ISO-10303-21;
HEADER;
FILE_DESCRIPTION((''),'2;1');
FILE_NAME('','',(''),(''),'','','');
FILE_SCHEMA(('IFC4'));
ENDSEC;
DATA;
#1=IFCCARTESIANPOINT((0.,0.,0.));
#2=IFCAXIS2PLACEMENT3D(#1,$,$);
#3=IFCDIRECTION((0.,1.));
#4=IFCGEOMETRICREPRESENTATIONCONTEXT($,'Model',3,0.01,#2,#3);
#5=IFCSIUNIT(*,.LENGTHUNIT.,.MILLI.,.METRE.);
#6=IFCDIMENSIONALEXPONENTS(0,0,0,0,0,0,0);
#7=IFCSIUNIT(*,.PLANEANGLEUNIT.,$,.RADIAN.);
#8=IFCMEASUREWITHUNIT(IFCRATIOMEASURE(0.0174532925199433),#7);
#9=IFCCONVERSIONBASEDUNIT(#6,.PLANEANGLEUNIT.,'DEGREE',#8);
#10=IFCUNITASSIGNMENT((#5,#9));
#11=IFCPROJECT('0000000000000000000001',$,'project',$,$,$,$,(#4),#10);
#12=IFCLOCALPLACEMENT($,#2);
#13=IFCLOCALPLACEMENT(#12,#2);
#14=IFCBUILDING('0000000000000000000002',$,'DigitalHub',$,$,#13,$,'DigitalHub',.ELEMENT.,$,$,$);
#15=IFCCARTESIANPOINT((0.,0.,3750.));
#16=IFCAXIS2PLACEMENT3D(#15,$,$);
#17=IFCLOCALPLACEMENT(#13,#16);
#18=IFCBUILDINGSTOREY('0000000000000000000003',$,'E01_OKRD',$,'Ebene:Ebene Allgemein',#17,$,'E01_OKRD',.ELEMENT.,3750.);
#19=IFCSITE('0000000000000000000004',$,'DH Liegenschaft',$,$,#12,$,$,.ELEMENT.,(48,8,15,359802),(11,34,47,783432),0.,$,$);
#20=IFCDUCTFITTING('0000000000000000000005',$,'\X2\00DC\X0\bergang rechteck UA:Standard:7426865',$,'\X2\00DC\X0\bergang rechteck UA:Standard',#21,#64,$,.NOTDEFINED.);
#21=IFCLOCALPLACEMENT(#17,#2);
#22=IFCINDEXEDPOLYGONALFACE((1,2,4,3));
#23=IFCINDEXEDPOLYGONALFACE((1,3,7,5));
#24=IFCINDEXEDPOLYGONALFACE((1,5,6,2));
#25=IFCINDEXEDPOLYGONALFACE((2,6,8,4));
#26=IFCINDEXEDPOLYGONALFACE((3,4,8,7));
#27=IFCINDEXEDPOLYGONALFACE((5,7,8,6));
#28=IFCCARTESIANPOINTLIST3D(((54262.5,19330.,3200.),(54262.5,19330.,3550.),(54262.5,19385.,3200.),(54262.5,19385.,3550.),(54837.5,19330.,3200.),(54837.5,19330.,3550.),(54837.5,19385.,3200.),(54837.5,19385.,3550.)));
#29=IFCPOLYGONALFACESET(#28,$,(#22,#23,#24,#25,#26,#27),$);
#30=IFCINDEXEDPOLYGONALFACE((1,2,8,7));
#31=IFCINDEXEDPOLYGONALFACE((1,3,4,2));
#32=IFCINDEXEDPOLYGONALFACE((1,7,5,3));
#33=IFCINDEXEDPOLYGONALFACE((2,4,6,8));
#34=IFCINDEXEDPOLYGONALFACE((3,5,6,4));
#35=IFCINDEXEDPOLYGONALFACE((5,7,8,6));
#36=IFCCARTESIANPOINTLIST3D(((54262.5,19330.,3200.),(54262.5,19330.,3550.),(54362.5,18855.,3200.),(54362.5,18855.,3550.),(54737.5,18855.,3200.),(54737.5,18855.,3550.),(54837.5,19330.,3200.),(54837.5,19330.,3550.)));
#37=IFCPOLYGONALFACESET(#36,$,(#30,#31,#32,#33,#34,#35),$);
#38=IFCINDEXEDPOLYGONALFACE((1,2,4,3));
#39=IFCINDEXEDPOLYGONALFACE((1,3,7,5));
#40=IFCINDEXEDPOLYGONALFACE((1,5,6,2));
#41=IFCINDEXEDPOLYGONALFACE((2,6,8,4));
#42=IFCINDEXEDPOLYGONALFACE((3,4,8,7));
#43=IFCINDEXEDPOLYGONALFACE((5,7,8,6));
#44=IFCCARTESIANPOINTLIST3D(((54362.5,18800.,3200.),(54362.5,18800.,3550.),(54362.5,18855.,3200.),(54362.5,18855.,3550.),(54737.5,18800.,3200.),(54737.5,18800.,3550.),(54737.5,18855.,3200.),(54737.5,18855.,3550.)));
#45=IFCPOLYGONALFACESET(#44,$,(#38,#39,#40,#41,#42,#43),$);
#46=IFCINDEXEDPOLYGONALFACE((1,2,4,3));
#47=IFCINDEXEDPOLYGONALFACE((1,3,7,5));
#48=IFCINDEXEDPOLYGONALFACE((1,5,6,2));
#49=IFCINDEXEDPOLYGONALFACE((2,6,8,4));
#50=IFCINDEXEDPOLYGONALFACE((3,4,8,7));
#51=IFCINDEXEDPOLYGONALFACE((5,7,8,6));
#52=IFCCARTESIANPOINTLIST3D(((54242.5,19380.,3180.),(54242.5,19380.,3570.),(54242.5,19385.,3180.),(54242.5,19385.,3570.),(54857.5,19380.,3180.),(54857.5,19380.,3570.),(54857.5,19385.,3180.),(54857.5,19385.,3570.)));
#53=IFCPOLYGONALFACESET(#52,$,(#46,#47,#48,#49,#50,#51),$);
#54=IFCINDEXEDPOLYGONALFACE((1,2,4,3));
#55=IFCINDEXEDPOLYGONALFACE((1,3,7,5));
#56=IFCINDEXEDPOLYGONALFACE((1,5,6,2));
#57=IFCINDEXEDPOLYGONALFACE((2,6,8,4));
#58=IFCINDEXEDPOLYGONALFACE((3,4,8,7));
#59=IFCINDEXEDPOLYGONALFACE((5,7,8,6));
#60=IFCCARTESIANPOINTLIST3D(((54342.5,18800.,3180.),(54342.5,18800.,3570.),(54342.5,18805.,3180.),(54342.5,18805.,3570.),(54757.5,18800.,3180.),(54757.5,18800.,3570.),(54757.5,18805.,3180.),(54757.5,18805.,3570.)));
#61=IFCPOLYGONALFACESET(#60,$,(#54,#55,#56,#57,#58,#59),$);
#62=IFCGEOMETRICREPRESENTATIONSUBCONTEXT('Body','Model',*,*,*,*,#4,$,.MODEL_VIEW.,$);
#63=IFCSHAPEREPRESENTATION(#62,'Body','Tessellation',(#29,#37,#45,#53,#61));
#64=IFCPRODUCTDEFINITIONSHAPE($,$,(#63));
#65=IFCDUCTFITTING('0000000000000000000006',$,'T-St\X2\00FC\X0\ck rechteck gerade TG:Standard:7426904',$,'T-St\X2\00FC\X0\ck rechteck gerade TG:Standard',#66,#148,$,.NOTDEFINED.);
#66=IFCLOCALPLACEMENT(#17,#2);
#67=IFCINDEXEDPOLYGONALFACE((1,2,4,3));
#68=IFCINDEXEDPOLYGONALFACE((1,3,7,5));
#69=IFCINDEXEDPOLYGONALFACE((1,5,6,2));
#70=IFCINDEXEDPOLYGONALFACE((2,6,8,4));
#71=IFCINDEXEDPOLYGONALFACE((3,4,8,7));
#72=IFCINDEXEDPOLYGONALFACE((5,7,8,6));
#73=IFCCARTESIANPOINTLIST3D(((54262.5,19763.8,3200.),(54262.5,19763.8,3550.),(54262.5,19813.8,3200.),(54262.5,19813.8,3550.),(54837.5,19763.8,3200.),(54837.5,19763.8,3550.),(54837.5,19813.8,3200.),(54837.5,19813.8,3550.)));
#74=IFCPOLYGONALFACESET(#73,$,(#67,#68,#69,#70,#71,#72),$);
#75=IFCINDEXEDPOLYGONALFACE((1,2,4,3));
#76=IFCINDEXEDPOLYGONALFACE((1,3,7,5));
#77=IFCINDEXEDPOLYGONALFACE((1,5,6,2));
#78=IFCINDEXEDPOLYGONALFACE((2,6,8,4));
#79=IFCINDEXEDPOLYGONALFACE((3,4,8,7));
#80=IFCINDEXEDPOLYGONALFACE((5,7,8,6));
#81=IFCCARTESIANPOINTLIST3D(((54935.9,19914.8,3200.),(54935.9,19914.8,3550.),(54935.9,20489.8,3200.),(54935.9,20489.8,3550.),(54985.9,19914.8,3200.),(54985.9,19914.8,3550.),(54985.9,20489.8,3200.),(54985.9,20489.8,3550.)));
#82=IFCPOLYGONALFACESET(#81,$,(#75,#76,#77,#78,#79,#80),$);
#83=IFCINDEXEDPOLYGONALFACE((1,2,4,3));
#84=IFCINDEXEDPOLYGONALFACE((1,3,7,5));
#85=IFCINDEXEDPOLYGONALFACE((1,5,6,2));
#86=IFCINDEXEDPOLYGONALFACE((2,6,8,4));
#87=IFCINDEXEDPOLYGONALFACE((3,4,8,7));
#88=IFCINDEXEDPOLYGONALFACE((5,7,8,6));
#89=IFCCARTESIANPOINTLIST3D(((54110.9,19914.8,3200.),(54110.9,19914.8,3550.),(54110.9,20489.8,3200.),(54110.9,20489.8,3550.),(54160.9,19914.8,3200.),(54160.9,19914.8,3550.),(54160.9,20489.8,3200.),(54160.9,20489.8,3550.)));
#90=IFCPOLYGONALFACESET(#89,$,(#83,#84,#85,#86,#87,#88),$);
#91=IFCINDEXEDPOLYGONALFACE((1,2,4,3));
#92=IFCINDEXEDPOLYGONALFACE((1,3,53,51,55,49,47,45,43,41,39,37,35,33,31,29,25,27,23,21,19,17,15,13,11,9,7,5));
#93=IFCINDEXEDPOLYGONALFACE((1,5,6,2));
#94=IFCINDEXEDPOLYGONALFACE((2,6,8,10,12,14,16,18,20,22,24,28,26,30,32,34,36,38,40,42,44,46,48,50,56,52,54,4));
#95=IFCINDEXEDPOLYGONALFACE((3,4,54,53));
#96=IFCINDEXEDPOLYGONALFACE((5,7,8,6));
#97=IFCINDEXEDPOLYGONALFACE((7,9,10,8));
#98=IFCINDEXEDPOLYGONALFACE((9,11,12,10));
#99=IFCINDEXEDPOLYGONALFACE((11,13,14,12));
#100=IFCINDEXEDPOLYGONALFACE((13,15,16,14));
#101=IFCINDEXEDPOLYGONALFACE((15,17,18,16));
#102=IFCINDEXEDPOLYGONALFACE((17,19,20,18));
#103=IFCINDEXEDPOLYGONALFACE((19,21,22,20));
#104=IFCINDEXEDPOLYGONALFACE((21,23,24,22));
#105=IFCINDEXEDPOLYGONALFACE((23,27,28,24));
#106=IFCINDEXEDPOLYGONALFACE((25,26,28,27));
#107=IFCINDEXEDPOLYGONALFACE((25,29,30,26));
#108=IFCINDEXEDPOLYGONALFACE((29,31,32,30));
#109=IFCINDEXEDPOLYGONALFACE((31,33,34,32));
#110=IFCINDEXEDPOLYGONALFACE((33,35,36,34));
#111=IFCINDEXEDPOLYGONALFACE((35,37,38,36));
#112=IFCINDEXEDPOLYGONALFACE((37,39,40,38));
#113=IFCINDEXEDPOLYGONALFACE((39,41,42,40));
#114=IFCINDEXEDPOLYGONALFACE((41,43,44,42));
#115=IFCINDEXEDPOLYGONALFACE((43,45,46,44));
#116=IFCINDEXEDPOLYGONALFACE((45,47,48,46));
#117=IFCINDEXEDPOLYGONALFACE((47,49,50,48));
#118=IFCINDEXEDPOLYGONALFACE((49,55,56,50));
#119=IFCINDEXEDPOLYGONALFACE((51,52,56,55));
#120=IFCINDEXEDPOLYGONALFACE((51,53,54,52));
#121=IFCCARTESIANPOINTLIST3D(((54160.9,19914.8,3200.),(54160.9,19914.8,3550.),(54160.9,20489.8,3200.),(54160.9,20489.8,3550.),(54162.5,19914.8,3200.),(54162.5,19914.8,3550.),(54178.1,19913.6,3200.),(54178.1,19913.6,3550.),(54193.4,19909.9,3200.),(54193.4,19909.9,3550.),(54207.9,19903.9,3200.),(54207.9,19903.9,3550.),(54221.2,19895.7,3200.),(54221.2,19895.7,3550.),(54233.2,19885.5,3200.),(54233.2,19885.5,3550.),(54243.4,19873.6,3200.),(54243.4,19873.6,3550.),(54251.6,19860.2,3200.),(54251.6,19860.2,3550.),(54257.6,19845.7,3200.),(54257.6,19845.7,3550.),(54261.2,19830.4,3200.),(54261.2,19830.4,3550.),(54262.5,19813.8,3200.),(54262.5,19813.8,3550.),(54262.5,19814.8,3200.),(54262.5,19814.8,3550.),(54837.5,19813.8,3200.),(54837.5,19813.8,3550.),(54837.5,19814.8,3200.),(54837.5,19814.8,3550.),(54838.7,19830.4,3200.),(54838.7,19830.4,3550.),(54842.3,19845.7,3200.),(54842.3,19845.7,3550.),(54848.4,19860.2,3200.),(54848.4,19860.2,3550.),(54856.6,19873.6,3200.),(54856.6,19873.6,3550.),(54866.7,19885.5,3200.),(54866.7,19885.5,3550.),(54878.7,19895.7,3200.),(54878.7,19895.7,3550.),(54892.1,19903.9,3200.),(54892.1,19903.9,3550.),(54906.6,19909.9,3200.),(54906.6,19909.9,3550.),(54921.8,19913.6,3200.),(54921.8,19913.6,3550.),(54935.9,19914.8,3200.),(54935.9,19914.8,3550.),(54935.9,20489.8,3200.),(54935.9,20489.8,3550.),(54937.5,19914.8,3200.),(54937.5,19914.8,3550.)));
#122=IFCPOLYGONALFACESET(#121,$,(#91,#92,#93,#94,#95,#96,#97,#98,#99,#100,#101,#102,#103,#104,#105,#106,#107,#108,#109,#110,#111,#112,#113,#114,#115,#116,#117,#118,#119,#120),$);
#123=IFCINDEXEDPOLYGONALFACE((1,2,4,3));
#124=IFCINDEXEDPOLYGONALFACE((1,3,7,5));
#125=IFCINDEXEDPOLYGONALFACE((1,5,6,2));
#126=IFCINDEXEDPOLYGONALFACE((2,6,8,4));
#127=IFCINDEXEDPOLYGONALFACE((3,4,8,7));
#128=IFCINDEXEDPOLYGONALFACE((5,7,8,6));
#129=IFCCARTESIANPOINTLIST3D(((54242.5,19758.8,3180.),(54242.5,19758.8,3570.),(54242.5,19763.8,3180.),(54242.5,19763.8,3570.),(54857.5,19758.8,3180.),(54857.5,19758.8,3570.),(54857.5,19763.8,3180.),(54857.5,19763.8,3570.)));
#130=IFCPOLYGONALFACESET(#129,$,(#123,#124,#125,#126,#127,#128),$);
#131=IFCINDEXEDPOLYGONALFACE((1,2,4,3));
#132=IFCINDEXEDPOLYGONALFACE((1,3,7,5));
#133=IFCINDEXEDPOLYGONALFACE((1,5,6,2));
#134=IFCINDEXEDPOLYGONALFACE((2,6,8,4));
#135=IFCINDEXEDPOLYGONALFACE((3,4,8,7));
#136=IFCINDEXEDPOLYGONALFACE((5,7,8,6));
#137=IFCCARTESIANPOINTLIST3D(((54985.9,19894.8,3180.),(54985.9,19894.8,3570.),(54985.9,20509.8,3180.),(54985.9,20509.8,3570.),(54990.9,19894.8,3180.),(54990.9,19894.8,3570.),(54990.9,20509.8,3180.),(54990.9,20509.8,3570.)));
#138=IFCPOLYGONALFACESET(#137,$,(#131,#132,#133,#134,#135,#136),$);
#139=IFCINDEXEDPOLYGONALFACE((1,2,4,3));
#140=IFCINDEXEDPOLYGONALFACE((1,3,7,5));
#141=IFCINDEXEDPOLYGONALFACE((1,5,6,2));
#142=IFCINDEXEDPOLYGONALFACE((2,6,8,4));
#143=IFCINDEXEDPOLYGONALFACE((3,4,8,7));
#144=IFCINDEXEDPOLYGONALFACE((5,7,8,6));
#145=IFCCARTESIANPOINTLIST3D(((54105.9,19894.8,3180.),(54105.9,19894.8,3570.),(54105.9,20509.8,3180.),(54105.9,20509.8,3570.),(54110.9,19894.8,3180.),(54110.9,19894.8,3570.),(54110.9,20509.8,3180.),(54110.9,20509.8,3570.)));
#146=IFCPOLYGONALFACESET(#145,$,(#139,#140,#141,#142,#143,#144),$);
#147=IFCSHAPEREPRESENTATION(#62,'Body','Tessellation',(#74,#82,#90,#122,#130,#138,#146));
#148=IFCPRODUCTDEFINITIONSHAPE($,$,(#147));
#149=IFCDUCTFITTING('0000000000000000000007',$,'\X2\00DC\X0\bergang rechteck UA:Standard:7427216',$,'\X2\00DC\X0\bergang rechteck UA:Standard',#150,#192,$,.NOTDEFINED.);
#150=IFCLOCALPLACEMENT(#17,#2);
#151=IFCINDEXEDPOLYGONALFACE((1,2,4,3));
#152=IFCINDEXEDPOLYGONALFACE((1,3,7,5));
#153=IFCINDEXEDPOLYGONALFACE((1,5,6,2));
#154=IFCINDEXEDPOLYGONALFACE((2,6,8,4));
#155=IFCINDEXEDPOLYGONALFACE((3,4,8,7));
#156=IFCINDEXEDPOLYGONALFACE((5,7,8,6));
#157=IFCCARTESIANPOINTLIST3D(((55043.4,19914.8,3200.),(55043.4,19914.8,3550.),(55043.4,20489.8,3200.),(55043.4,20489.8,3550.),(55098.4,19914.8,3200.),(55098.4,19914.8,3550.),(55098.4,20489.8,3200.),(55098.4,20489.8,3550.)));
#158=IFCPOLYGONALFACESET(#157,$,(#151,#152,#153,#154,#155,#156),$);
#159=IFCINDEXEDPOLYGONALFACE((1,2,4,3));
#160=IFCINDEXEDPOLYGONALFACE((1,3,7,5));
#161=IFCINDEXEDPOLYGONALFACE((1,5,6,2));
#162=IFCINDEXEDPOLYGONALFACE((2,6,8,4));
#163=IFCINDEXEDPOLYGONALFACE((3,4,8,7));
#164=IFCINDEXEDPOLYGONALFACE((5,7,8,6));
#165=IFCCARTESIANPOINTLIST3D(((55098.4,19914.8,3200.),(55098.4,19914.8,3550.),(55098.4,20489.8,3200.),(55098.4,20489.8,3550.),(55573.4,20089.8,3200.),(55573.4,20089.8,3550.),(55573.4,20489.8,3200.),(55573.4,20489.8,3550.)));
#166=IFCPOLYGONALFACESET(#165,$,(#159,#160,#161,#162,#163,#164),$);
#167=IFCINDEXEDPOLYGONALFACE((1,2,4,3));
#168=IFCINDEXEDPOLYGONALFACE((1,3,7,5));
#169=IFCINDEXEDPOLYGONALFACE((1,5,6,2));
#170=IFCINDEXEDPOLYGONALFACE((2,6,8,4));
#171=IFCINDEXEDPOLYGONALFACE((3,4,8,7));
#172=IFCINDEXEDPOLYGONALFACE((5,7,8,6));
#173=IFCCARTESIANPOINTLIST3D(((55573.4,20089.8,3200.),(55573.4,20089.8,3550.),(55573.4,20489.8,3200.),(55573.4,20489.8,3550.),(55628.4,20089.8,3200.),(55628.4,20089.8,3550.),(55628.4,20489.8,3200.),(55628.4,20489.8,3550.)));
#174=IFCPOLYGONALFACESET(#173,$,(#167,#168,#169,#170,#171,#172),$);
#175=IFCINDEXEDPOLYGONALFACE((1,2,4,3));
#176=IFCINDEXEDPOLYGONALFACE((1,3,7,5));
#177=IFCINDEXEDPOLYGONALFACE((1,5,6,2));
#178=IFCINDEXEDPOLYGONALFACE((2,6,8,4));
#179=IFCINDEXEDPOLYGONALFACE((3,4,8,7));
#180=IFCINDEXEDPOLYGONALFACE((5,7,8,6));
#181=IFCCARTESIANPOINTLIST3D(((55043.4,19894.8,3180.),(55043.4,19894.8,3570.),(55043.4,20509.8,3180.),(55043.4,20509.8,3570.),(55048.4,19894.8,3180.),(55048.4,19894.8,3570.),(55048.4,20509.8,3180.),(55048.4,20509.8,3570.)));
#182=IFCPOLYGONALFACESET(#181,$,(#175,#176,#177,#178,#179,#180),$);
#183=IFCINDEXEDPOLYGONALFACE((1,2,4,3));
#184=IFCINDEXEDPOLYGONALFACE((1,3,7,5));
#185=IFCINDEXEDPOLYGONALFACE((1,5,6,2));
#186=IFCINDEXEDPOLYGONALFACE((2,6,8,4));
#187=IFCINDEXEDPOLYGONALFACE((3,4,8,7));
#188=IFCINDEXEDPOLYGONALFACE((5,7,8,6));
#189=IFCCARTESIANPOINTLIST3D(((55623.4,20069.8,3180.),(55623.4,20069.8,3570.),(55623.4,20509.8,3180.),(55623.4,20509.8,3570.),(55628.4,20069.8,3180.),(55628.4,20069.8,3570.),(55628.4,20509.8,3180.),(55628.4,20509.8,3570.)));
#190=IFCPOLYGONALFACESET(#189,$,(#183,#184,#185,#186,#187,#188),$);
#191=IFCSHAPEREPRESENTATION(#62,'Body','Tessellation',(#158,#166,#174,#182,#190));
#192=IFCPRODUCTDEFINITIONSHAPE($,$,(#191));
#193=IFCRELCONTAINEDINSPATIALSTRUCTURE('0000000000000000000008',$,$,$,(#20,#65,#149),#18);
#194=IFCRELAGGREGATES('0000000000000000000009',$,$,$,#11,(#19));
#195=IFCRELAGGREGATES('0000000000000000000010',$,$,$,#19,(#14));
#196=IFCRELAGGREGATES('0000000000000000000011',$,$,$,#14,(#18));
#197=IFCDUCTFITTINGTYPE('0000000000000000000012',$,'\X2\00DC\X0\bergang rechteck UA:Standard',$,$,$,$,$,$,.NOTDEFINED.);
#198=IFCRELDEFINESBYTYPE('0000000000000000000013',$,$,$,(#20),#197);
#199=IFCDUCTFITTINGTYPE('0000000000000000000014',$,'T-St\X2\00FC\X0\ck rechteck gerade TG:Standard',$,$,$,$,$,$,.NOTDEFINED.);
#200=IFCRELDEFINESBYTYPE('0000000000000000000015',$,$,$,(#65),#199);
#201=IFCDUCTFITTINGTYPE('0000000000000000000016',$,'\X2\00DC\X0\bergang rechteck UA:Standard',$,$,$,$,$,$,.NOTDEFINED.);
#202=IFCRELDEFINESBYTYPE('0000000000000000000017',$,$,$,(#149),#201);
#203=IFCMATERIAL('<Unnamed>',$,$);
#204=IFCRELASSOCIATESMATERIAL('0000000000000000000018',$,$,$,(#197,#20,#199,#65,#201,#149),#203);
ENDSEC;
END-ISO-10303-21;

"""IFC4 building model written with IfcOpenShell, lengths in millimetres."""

from ifc_helpers import new_model, entity, si_unit, converted_unit, direction, frame, origin, place, context, subcontext, project, spatial, indexed_curve, outline, extrude, source, transform, mapped, material, type_object, type_shapes, element, save


model = new_model("IFC4")

# Units and contexts
model_context = context("Model", 3, precision=0.01, world=origin(), true_north=direction((0.0, 1.0)))
body_context = subcontext(model_context, "Body", "Model", "MODEL_VIEW")
ifc_project = project(units=[si_unit("LENGTHUNIT", "METRE", prefix="MILLI"), converted_unit("PLANEANGLEUNIT", "DEGREE", entity("IfcRatioMeasure", 0.0174532925199433), si_unit("PLANEANGLEUNIT", "RADIAN"), dimensions=[0, 0, 0, 0, 0, 0, 0])], contexts=[model_context])

# Site, building, storey
site_placement = place(None, origin())
site = spatial("IfcSite", under=ifc_project, at=site_placement, Name="DH Liegenschaft", CompositionType="ELEMENT", RefLatitude=(48, 8, 15, 359802), RefLongitude=(11, 34, 47, 783432), RefElevation=0.0)
building_placement = place(site_placement, origin())
building = spatial("IfcBuilding", under=site, at=building_placement, Name="DigitalHub", LongName="DigitalHub", CompositionType="ELEMENT")
storey_placement = place(building_placement, frame((0.0, 0.0, 3750.0)))
storey = spatial("IfcBuildingStorey", under=building, at=storey_placement, Name="E01_OKRD", ObjectType="Ebene:Ebene Allgemein", LongName="E01_OKRD", CompositionType="ELEMENT", Elevation=3750.0)

# Shared definitions
ifc_material_1 = material(Name="<Unnamed>")

# Duct fittings
duct_fitting_type_1 = type_object("IfcDuctFittingType", Name="Übergang rechteck UA:Standard", PredefinedType="NOTDEFINED", material=ifc_material_1)
shared_shape_1 = source(origin(), body_context, "Body", "SweptSolid", [
    extrude(outline(indexed_curve([(-27.5, -287.5), (27.5, -287.5), (27.5, 287.5), (-27.5, 287.5), (-27.5, -287.5)], self_intersect=False)), frame((557.5, 0.0, -175.0)), (0.0, 0.0, 1.0), 350.0),
    extrude(outline(indexed_curve([(-193.8, -232.4), (291.6, -232.4), (173.2, 330.3), (-271.0, 134.6), (-193.8, -232.4)], self_intersect=False)), frame((292.5, 0.0, -175.0), z_axis=(0.0, 0.0, 1.0), x_axis=(0.97855, -0.20601, 0.0)), (0.0, 0.0, 1.0), 350.0),
    extrude(outline(indexed_curve([(-27.5, -187.5), (27.5, -187.5), (27.5, 187.5), (-27.5, 187.5), (-27.5, -187.5)], self_intersect=False)), frame((27.5, 0.0, -175.0)), (0.0, 0.0, 1.0), 350.0),
    extrude(outline(indexed_curve([(-2.5, -307.5), (2.5, -307.5), (2.5, 307.5), (-2.5, 307.5), (-2.5, -307.5)], self_intersect=False)), frame((582.5, 0.0, -195.0)), (0.0, 0.0, 1.0), 390.0),
    extrude(outline(indexed_curve([(-2.5, -207.5), (2.5, -207.5), (2.5, 207.5), (-2.5, 207.5), (-2.5, -207.5)], self_intersect=False)), frame((2.5, 0.0, -195.0)), (0.0, 0.0, 1.0), 390.0),
])
type_shapes(duct_fitting_type_1, [shared_shape_1])
duct_fitting_1_placement = place(storey_placement, frame((54550.0, 18800.0, 3375.0), z_axis=(0.0, 0.0, 1.0), x_axis=(0.0, 1.0, 0.0)))
element("IfcDuctFitting", 1, at=duct_fitting_1_placement, inside=storey, type_object=duct_fitting_type_1, material=ifc_material_1, Name="Übergang rechteck UA:Standard:7426865", ObjectType="Übergang rechteck UA:Standard", PredefinedType="NOTDEFINED", context=body_context, shape_type="MappedRepresentation", body=[
    mapped(shared_shape_1, transform((0.0, 0.0, 0.0), scale=1.0)),
])
duct_fitting_type_2 = type_object("IfcDuctFittingType", Name="T-Stück rechteck gerade TG:Standard", PredefinedType="NOTDEFINED", material=ifc_material_1)
shared_shape_2 = source(origin(), body_context, "Body", "SweptSolid", [
    extrude(outline(indexed_curve([(-25.0, -287.5), (25.0, -287.5), (25.0, 287.5), (-25.0, 287.5), (-25.0, -287.5)], self_intersect=False)), frame((0.0, -413.5, -175.0), z_axis=(0.0, 0.0, 1.0), x_axis=(0.0, -1.0, 0.0)), (0.0, 0.0, 1.0), 350.0),
    extrude(outline(indexed_curve([(-25.0, -287.5), (25.0, -287.5), (25.0, 287.5), (-25.0, 287.5), (-25.0, -287.5)], self_intersect=False)), frame((410.9, 0.0, -175.0), z_axis=(0.0, 0.0, 1.0), x_axis=(-1.0, 0.0, 0.0)), (0.0, 0.0, 1.0), 350.0),
    extrude(outline(indexed_curve([(-25.0, -287.5), (25.0, -287.5), (25.0, 287.5), (-25.0, 287.5), (-25.0, -287.5)], self_intersect=False)), frame((-414.1, 0.0, -175.0)), (0.0, 0.0, 1.0), 350.0),
    extrude(outline(indexed_curve([(-388.1, -74.8), (-372.5, -76.0), (-357.2, -79.7), (-342.7, -85.7), (-329.4, -93.9), (-317.4, -104.1), (-307.2, -116.0), (-299.0, -129.4), (-293.0, -143.9), (-289.4, -159.2), (-288.1, -174.8), (-288.1, -175.8), (286.9, -175.8), (286.9, -174.8), (288.1, -159.2), (291.8, -143.9), (297.8, -129.4), (306.0, -116.0), (316.1, -104.1), (328.1, -93.9), (341.5, -85.7), (356.0, -79.7), (371.2, -76.0), (386.9, -74.8), (388.5, -74.8), (388.5, 500.2), (-386.5, 500.2), (-386.5, -74.8), (-388.1, -74.8)], self_intersect=False)), frame((-0.6, -212.7, -175.0), z_axis=(0.0, 0.0, -1.0), x_axis=(-1.0, 0.0, 0.0)), (0.0, 0.0, -1.0), 350.0),
    extrude(outline(indexed_curve([(-2.5, -307.5), (2.5, -307.5), (2.5, 307.5), (-2.5, 307.5), (-2.5, -307.5)], self_intersect=False)), frame((0.0, -441.0, -195.0), z_axis=(0.0, 0.0, 1.0), x_axis=(0.0, 1.0, 0.0)), (0.0, 0.0, 1.0), 390.0),
    extrude(outline(indexed_curve([(-2.5, -307.5), (2.5, -307.5), (2.5, 307.5), (-2.5, 307.5), (-2.5, -307.5)], self_intersect=False)), frame((438.4, 0.0, -195.0), z_axis=(0.0, 0.0, 1.0), x_axis=(-1.0, 0.0, 0.0)), (0.0, 0.0, 1.0), 390.0),
    extrude(outline(indexed_curve([(-2.5, -307.5), (2.5, -307.5), (2.5, 307.5), (-2.5, 307.5), (-2.5, -307.5)], self_intersect=False)), frame((-441.6, 0.0, -195.0), z_axis=(0.0, 0.0, 1.0), x_axis=(-1.0, 0.0, 0.0)), (0.0, 0.0, 1.0), 390.0),
])
type_shapes(duct_fitting_type_2, [shared_shape_2])
duct_fitting_2_placement = place(storey_placement, frame((54550.0, 20202.3, 3375.0)))
element("IfcDuctFitting", 2, at=duct_fitting_2_placement, inside=storey, type_object=duct_fitting_type_2, material=ifc_material_1, Name="T-Stück rechteck gerade TG:Standard:7426904", ObjectType="T-Stück rechteck gerade TG:Standard", PredefinedType="NOTDEFINED", context=body_context, shape_type="MappedRepresentation", body=[
    mapped(shared_shape_2, transform((0.0, 0.0, 0.0), scale=1.0)),
])
duct_fitting_type_3 = type_object("IfcDuctFittingType", Name="Übergang rechteck UA:Standard", PredefinedType="NOTDEFINED", material=ifc_material_1)
shared_shape_3 = source(origin(), body_context, "Body", "SweptSolid", [
    extrude(outline(indexed_curve([(-27.5, -287.5), (27.5, -287.5), (27.5, 287.5), (-27.5, 287.5), (-27.5, -287.5)], self_intersect=False)), frame((557.5, 87.5, -175.0)), (0.0, 0.0, 1.0), 350.0),
    extrude(outline(indexed_curve([(-237.5, -243.8), (237.5, -243.8), (237.5, 331.2), (-237.5, 156.2), (-237.5, -243.8)], self_intersect=False)), frame((292.5, 43.8, -175.0)), (0.0, 0.0, 1.0), 350.0),
    extrude(outline(indexed_curve([(-27.5, -200.0), (27.5, -200.0), (27.5, 200.0), (-27.5, 200.0), (-27.5, -200.0)], self_intersect=False)), frame((27.5, 0.0, -175.0)), (0.0, 0.0, 1.0), 350.0),
    extrude(outline(indexed_curve([(-2.5, -307.5), (2.5, -307.5), (2.5, 307.5), (-2.5, 307.5), (-2.5, -307.5)], self_intersect=False)), frame((582.5, 87.5, -195.0)), (0.0, 0.0, 1.0), 390.0),
    extrude(outline(indexed_curve([(-2.5, -220.0), (2.5, -220.0), (2.5, 220.0), (-2.5, 220.0), (-2.5, -220.0)], self_intersect=False)), frame((2.5, 0.0, -195.0)), (0.0, 0.0, 1.0), 390.0),
])
type_shapes(duct_fitting_type_3, [shared_shape_3])
duct_fitting_3_placement = place(storey_placement, frame((55628.4, 20289.8, 3375.0), z_axis=(0.0, 0.0, 1.0), x_axis=(-1.0, 0.0, 0.0)))
element("IfcDuctFitting", 3, at=duct_fitting_3_placement, inside=storey, type_object=duct_fitting_type_3, material=ifc_material_1, Name="Übergang rechteck UA:Standard:7427216", ObjectType="Übergang rechteck UA:Standard", PredefinedType="NOTDEFINED", context=body_context, shape_type="MappedRepresentation", body=[
    mapped(shared_shape_3, transform((0.0, 0.0, 0.0), scale=1.0)),
])

save(model, "model.ifc")
